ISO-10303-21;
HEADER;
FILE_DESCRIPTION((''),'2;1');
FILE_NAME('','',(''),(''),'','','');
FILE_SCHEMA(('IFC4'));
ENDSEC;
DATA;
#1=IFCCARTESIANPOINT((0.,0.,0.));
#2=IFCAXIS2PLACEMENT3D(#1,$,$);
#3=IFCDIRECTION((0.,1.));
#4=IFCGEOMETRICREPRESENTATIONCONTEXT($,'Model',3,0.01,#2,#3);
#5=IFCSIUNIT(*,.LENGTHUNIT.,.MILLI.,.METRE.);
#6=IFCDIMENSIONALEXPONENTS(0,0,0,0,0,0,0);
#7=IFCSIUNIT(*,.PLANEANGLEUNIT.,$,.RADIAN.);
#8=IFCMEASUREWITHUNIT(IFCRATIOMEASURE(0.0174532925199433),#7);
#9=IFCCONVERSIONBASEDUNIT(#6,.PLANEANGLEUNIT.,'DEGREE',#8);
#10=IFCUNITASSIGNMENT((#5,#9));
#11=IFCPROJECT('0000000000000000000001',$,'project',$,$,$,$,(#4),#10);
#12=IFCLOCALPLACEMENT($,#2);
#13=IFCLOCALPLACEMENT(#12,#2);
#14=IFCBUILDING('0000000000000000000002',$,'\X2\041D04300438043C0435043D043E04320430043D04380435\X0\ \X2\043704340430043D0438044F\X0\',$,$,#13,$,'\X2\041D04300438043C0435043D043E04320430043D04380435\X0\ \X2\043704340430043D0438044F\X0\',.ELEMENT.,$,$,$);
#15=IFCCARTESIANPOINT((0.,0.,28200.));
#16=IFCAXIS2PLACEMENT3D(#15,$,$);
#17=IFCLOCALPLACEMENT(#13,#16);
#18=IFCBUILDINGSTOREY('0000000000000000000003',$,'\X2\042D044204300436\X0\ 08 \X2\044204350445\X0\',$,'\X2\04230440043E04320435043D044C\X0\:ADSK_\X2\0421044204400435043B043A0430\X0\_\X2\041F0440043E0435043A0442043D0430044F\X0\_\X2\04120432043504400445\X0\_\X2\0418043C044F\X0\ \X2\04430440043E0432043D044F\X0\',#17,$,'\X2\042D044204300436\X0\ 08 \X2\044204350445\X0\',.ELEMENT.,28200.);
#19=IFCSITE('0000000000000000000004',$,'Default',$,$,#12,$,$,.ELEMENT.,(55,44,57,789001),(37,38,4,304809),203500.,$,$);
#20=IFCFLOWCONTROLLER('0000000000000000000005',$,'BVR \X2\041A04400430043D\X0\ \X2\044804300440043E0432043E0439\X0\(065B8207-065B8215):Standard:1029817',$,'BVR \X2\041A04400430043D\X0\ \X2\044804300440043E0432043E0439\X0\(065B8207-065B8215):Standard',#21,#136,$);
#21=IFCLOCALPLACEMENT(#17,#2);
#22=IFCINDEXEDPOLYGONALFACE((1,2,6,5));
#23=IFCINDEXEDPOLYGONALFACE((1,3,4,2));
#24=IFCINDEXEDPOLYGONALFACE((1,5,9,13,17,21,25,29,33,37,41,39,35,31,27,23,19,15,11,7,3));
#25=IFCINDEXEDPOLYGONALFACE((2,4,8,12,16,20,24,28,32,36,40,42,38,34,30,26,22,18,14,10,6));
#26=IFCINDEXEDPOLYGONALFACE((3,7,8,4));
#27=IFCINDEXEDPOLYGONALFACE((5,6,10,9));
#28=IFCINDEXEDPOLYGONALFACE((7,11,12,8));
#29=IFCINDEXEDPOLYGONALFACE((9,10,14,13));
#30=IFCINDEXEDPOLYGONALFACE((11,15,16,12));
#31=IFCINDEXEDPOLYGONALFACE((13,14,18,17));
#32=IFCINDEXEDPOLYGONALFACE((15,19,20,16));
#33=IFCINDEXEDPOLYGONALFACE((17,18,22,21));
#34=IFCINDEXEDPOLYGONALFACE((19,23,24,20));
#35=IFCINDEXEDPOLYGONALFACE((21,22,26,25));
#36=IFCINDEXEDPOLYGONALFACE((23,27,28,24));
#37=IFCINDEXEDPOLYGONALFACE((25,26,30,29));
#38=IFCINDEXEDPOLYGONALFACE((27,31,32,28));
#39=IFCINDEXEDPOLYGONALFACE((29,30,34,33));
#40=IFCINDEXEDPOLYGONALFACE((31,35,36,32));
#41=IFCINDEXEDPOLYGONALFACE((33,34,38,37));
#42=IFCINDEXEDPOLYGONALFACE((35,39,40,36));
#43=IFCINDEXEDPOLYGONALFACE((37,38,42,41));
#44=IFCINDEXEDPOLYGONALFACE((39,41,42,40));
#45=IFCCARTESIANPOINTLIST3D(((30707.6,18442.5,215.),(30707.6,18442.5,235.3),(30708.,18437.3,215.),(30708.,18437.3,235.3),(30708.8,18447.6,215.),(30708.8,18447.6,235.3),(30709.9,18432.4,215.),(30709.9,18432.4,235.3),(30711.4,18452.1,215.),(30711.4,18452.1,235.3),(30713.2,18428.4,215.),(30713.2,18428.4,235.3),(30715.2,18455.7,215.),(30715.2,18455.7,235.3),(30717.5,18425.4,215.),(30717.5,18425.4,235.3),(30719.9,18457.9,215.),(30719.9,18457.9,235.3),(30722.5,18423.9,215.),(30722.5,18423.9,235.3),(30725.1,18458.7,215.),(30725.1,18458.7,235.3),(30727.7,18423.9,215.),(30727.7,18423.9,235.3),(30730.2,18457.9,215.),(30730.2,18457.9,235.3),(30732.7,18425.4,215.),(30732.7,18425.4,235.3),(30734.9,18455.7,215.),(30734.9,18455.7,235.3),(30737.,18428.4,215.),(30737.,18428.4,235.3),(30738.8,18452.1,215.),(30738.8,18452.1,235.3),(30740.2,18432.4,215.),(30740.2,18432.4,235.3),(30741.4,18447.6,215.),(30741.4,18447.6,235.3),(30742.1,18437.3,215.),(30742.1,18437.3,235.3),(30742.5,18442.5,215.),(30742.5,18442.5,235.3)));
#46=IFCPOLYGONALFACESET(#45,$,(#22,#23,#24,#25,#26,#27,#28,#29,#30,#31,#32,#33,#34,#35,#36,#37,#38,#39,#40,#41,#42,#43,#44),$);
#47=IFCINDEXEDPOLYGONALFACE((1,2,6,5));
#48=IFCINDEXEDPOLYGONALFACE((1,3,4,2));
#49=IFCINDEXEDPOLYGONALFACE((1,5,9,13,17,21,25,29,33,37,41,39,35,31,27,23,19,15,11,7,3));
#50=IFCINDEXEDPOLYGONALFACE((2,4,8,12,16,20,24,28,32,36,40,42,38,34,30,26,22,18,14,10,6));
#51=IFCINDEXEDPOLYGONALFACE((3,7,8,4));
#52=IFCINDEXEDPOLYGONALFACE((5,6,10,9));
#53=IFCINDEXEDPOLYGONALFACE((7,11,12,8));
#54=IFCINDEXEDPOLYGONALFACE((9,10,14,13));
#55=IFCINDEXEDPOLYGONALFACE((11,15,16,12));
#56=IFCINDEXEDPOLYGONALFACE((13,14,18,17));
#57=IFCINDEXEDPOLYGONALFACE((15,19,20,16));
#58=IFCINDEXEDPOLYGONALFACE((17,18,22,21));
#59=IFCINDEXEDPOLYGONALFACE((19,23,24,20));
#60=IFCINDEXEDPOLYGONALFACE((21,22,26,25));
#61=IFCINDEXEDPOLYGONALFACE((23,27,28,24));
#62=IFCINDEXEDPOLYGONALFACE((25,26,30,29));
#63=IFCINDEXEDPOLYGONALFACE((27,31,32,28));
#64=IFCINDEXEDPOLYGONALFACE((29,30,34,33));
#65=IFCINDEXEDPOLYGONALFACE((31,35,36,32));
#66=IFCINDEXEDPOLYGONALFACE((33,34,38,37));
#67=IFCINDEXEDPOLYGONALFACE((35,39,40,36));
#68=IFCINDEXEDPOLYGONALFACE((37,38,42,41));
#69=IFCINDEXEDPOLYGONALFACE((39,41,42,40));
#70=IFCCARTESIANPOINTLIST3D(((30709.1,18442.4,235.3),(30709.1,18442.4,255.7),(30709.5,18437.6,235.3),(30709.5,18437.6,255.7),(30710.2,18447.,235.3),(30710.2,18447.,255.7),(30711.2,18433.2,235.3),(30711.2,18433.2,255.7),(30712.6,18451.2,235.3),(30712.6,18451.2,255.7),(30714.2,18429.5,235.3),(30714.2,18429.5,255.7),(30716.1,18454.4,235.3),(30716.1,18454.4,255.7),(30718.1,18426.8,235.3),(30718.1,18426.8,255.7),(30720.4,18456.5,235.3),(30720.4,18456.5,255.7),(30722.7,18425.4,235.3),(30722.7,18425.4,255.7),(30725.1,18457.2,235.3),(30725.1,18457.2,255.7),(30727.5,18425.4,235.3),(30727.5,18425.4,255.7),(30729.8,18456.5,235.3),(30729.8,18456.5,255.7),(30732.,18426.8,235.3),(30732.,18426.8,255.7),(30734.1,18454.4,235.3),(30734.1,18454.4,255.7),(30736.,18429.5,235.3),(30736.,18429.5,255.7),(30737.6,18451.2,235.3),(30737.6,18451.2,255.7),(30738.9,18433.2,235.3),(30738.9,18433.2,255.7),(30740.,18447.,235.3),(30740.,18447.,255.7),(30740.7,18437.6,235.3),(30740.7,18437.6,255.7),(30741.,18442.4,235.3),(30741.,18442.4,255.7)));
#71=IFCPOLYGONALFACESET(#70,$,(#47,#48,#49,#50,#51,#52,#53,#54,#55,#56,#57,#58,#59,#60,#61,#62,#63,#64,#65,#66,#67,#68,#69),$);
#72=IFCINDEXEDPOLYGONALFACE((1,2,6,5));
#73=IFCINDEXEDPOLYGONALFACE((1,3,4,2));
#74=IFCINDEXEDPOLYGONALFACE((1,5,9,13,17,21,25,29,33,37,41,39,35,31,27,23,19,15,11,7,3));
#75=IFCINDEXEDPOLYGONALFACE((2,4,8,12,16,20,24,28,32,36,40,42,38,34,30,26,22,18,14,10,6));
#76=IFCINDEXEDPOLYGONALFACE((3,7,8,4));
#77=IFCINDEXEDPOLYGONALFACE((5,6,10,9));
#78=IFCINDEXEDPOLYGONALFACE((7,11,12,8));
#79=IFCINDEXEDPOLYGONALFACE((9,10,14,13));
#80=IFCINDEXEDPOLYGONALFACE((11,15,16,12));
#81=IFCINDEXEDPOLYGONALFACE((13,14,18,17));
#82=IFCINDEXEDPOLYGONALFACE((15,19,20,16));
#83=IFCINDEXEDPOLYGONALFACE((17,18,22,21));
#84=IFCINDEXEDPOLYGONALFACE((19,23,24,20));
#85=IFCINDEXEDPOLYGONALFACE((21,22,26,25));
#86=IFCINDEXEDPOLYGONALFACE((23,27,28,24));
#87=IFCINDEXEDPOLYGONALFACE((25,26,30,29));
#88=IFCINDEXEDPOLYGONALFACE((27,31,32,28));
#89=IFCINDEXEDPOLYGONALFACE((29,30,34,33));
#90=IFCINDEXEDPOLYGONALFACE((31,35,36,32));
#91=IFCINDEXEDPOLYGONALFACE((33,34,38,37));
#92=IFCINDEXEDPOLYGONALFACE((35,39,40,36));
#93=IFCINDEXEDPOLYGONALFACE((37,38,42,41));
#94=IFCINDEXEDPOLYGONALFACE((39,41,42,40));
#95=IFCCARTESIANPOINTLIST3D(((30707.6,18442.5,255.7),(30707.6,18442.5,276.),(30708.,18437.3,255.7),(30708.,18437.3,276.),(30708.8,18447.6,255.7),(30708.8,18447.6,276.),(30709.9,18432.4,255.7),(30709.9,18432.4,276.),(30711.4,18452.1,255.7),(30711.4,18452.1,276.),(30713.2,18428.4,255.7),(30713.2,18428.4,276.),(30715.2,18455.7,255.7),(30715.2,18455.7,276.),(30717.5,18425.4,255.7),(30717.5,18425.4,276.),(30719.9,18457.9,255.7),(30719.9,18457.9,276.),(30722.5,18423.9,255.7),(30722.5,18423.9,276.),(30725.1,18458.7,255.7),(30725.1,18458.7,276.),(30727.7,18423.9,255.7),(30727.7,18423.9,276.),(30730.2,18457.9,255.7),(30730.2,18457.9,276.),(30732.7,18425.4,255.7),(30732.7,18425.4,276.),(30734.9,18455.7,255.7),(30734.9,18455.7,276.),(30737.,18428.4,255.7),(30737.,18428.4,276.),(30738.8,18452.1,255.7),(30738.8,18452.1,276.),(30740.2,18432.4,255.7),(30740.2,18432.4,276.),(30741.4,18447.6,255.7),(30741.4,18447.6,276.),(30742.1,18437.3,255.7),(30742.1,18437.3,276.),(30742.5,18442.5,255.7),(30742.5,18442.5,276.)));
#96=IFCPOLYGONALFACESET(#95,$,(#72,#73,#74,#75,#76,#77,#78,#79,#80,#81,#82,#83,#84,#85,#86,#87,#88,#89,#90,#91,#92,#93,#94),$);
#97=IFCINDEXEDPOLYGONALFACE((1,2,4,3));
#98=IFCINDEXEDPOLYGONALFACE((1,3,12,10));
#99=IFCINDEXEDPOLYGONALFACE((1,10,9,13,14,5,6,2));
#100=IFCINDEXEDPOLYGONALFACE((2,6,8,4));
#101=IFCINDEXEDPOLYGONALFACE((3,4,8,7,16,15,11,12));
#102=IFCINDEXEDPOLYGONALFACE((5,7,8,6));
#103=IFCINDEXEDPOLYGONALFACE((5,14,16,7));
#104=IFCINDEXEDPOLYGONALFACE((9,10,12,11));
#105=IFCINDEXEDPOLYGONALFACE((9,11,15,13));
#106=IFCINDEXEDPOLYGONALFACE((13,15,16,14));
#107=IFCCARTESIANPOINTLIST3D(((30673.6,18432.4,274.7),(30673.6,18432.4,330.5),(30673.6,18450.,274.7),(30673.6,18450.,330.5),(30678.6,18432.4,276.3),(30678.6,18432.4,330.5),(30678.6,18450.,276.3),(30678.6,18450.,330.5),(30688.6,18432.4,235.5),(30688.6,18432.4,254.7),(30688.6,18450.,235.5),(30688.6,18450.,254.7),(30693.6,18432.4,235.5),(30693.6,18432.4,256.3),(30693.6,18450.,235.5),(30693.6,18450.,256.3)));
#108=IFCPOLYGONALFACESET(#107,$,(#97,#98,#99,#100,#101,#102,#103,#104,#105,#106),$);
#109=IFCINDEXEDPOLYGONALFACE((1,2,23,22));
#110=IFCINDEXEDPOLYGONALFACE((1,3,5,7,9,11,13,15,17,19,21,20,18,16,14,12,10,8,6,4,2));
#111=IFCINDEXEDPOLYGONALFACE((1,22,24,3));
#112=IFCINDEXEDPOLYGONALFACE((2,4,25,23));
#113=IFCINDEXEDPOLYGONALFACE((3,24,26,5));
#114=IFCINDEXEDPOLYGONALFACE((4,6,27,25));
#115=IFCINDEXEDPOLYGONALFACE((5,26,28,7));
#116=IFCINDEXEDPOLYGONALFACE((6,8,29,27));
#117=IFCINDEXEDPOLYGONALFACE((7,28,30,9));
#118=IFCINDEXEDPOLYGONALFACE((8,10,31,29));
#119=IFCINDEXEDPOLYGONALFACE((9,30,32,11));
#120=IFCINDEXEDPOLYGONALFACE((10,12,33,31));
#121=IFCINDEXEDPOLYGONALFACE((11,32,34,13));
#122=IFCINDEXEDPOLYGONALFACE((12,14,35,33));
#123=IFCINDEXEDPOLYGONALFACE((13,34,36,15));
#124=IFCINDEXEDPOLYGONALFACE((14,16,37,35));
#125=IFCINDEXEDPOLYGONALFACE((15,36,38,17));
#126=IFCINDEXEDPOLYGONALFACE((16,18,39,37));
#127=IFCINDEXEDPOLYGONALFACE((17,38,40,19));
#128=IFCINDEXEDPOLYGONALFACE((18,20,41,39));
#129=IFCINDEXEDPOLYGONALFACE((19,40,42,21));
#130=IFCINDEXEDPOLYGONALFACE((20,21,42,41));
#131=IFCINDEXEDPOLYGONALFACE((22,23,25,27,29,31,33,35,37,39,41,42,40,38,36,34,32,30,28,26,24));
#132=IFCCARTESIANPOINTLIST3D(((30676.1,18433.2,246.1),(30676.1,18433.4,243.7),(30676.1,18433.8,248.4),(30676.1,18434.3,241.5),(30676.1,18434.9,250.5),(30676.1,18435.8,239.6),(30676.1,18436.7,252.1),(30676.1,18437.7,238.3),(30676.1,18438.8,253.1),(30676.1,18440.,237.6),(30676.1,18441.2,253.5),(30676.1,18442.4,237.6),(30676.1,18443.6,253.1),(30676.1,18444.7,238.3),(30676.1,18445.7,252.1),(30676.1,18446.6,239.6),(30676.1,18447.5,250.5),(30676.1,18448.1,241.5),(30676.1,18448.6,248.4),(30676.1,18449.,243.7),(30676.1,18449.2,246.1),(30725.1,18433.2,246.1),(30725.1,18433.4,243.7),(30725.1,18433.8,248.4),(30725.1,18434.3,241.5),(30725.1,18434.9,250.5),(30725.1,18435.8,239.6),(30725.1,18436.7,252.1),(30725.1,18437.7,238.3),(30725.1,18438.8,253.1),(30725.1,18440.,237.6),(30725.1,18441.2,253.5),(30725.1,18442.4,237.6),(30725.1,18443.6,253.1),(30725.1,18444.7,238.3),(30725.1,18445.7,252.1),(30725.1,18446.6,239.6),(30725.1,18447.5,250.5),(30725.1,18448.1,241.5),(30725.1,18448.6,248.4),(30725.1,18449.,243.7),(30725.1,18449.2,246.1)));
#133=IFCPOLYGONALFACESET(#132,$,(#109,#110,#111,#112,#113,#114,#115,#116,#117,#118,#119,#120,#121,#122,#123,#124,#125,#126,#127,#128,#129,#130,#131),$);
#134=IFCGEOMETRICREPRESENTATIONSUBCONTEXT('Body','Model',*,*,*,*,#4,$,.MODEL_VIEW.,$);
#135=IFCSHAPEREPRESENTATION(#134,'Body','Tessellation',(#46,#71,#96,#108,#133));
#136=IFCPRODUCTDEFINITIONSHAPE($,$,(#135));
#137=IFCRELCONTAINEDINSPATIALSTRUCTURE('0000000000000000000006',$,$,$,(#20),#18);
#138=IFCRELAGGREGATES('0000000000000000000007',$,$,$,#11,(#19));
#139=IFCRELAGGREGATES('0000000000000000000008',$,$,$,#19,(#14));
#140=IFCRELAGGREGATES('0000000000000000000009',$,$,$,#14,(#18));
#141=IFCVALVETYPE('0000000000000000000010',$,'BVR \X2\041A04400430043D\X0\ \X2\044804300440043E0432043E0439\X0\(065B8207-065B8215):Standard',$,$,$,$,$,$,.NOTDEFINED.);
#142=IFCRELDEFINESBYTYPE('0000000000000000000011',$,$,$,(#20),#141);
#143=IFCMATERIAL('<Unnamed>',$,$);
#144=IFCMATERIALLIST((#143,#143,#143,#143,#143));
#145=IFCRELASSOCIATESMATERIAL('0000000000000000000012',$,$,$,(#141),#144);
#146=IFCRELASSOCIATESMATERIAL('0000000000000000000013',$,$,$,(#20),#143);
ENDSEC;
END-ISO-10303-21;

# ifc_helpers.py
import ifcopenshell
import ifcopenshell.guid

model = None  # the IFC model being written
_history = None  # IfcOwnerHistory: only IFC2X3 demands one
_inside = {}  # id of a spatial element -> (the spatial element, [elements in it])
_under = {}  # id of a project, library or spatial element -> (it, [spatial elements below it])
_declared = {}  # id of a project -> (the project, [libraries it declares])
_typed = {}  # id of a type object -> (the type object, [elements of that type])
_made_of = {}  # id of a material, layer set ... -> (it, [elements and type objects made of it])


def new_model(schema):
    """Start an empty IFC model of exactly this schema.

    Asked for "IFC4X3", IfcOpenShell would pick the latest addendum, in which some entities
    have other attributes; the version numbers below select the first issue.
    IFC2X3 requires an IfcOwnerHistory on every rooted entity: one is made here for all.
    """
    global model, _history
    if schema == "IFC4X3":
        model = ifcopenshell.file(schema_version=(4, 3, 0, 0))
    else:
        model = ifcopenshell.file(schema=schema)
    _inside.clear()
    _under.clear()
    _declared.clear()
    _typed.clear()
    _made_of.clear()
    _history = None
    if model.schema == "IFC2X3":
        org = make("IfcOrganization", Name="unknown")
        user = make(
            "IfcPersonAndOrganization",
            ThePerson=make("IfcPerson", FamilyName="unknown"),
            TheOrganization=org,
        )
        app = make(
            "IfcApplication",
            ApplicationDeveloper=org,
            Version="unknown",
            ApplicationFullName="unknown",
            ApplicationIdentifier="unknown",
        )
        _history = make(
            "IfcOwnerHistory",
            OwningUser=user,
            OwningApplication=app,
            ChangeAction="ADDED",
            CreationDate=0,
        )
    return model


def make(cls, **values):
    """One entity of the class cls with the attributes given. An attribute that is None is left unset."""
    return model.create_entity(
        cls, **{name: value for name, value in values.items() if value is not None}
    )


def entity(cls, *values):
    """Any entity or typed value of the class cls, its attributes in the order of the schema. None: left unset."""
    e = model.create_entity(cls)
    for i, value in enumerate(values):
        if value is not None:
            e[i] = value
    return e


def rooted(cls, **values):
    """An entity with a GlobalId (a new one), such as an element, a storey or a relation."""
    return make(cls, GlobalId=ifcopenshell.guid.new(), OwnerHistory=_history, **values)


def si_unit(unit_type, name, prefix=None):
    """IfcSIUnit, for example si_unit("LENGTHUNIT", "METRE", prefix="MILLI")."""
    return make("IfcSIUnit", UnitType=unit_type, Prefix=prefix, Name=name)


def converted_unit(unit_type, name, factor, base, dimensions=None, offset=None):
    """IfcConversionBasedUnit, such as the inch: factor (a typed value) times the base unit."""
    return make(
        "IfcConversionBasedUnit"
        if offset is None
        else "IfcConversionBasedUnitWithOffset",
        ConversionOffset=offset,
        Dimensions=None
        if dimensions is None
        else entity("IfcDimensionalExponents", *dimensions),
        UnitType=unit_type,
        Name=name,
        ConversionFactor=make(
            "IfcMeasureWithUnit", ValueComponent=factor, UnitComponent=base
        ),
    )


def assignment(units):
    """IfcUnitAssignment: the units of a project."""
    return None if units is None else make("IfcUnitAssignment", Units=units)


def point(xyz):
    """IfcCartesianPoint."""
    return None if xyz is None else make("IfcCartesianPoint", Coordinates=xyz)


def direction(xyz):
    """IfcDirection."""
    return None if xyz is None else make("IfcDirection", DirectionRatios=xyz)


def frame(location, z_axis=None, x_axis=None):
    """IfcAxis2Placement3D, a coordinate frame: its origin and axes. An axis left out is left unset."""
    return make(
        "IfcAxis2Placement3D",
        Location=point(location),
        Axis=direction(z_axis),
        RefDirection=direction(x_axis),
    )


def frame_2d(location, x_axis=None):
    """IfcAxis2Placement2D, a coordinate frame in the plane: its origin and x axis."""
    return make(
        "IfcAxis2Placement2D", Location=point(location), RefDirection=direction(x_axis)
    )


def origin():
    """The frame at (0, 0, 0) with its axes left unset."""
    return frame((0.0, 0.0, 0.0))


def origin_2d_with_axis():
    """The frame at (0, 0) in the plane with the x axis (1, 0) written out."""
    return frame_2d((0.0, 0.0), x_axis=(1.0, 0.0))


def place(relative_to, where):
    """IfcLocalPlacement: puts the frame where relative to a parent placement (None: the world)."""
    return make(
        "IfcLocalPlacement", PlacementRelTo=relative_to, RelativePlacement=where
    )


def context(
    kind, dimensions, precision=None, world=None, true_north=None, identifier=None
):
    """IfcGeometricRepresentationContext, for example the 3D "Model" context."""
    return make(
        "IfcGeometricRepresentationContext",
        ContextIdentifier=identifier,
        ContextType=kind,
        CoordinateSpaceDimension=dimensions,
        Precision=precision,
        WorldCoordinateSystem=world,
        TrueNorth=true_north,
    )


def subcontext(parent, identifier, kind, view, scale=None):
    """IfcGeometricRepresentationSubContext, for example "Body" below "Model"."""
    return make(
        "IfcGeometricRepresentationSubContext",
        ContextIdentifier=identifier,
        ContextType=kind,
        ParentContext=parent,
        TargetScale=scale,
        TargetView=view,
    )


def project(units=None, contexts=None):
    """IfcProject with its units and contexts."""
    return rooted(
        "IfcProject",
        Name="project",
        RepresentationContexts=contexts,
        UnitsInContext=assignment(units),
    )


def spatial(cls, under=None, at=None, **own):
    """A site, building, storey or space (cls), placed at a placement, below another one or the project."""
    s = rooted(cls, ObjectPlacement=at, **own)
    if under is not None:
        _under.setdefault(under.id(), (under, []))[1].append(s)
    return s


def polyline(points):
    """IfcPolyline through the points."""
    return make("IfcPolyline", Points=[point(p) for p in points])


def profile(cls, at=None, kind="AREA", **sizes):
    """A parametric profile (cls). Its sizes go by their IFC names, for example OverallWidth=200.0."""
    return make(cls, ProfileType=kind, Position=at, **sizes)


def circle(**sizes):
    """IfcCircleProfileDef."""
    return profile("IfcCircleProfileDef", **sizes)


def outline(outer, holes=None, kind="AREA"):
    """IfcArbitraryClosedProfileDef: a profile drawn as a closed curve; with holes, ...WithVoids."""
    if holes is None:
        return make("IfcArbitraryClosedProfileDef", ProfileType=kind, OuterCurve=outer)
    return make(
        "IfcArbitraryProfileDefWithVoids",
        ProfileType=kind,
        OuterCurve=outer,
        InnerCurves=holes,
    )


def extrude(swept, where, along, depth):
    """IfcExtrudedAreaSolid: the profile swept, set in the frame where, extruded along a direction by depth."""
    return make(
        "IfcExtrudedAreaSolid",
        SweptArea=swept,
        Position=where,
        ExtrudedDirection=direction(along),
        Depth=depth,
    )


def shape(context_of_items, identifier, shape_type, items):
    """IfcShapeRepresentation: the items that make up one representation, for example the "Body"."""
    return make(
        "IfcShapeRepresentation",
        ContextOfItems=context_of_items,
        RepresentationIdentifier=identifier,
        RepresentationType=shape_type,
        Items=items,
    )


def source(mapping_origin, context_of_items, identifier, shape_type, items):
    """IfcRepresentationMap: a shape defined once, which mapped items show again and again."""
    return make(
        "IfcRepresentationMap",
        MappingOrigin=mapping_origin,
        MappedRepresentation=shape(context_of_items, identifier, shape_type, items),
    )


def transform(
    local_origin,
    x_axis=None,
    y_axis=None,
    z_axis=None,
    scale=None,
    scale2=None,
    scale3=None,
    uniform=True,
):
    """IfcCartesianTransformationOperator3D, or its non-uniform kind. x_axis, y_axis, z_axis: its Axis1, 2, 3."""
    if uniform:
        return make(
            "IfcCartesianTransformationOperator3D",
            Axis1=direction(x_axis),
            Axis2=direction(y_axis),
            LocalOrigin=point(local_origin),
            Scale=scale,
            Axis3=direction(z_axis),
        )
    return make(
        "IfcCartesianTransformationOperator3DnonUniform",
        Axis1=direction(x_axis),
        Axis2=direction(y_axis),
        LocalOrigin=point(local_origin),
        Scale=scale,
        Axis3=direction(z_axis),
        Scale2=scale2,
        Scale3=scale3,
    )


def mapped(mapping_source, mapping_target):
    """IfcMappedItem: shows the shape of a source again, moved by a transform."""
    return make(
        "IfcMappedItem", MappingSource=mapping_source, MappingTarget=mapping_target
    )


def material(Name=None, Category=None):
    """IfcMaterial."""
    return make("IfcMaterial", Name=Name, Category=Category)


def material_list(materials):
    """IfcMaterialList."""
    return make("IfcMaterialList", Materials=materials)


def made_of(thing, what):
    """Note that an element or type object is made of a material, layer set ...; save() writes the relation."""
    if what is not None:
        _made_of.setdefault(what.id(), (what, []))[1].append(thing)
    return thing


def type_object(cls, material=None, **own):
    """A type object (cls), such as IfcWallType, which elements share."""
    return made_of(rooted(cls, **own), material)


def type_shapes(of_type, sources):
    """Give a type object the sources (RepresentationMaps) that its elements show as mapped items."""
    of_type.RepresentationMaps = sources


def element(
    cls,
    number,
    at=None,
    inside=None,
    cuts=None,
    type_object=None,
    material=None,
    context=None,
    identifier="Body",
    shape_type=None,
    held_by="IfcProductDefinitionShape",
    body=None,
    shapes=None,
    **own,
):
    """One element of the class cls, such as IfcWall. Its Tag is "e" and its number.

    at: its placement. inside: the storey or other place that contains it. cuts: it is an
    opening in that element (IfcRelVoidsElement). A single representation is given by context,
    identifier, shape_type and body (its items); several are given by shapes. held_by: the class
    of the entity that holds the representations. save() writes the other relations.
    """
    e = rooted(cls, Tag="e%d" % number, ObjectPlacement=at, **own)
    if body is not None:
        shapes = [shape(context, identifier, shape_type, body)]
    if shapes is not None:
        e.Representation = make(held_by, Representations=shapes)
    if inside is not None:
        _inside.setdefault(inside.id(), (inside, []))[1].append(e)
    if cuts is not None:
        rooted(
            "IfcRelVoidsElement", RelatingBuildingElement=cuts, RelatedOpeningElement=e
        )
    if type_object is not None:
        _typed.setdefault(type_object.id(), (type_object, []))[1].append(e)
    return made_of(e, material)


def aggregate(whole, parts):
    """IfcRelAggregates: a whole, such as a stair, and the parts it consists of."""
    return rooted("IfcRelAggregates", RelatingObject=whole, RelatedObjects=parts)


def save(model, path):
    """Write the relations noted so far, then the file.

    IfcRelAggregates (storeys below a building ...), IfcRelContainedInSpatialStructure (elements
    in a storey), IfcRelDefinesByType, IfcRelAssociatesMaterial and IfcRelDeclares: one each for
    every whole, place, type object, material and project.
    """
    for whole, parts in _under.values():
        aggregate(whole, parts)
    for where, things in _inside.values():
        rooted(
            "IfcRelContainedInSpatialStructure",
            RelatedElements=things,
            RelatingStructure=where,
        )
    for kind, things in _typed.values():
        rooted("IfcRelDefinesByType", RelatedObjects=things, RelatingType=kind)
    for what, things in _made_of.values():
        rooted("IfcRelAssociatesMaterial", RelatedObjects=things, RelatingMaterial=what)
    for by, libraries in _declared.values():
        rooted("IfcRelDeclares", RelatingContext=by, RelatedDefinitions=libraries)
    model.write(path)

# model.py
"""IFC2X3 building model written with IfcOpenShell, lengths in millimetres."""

from ifc_helpers import new_model, entity, si_unit, converted_unit, direction, frame, origin, origin_2d_with_axis, place, context, subcontext, project, spatial, polyline, circle, outline, extrude, source, transform, mapped, material, material_list, type_object, type_shapes, element, save


model = new_model("IFC2X3")

# Units and contexts
model_context = context("Model", 3, precision=0.01, world=origin(), true_north=direction((0.0, 1.0)))
body_context = subcontext(model_context, "Body", "Model", "MODEL_VIEW")
ifc_project = project(units=[si_unit("LENGTHUNIT", "METRE", prefix="MILLI"), converted_unit("PLANEANGLEUNIT", "DEGREE", entity("IfcRatioMeasure", 0.0174532925199433), si_unit("PLANEANGLEUNIT", "RADIAN"), dimensions=[0, 0, 0, 0, 0, 0, 0])], contexts=[model_context])

# Site, building, storey
site_placement = place(None, origin())
site = spatial("IfcSite", under=ifc_project, at=site_placement, Name="Default", CompositionType="ELEMENT", RefLatitude=(55, 44, 57, 789001), RefLongitude=(37, 38, 4, 304809), RefElevation=203500.0)
building_placement = place(site_placement, origin())
building = spatial("IfcBuilding", under=site, at=building_placement, Name="Наименование здания", LongName="Наименование здания", CompositionType="ELEMENT")
storey_placement = place(building_placement, frame((0.0, 0.0, 28200.0)))
storey = spatial("IfcBuildingStorey", under=building, at=storey_placement, Name="Этаж 08 тех", ObjectType="Уровень:ADSK_Стрелка_Проектная_Вверх_Имя уровня", LongName="Этаж 08 тех", CompositionType="ELEMENT", Elevation=28200.0)

# Flow controller
ifc_material = material(Name="<Unnamed>")
ifc_material_list = material_list([ifc_material, ifc_material, ifc_material, ifc_material, ifc_material])
valve_type = type_object("IfcValveType", Name="BVR Кран шаровой(065B8207-065B8215):Standard", PredefinedType="NOTDEFINED", material=ifc_material_list)
shared_shape_1 = source(origin(), body_context, "Body", "SweptSolid", [
    extrude(circle(Radius=17.5, at=origin_2d_with_axis()), frame((-30.5, 0.0, 0.0), z_axis=(1.0, 0.0, 0.0), x_axis=(0.0, 1.0, 0.0)), (0.0, 0.0, 1.0), 20.3),
    extrude(circle(Radius=16.0, at=origin_2d_with_axis()), frame((-10.2, 0.0, 0.0), z_axis=(1.0, 0.0, 0.0), x_axis=(0.0, 1.0, 0.0)), (0.0, 0.0, 1.0), 20.3),
    extrude(circle(Radius=17.5, at=origin_2d_with_axis()), frame((10.2, 0.0, 0.0), z_axis=(1.0, 0.0, 0.0), x_axis=(0.0, 1.0, 0.0)), (0.0, 0.0, 1.0), 20.3),
    extrude(outline(polyline([(-38.8, -5.0), (-38.8, -10.0), (-17.9, -10.0), (2.1, 5.0), (56.2, 5.0), (56.2, 10.0), (0.4, 10.0), (-19.6, -5.0), (-38.8, -5.0)])), frame((28.8, -8.8, 41.5), z_axis=(0.0, -1.0, 0.0), x_axis=(1.0, 0.0, 0.0)), (0.0, 0.0, -1.0), 17.5),
    extrude(circle(Radius=8.0, at=origin_2d_with_axis()), origin(), (0.0, 0.0, 1.0), 49.0),
])
type_shapes(valve_type, [shared_shape_1])
for number, where, z_axis, x_axis, name in (
    (1, (30725.1, 18441.2, 245.5), (-1.0, 0.0, 0.0), (0.0, 0.0, 1.0), "BVR Кран шаровой(065B8207-065B8215):Standard:1029817"),
):
    element("IfcFlowController", number, at=place(storey_placement, frame(where, z_axis=z_axis, x_axis=x_axis)), inside=storey, type_object=valve_type, material=ifc_material, Name=name, ObjectType="BVR Кран шаровой(065B8207-065B8215):Standard", context=body_context, shape_type="MappedRepresentation", body=[
        mapped(shared_shape_1, transform((0.0, 0.0, 0.0), scale=1.0)),
    ])

save(model, "model.ifc")
